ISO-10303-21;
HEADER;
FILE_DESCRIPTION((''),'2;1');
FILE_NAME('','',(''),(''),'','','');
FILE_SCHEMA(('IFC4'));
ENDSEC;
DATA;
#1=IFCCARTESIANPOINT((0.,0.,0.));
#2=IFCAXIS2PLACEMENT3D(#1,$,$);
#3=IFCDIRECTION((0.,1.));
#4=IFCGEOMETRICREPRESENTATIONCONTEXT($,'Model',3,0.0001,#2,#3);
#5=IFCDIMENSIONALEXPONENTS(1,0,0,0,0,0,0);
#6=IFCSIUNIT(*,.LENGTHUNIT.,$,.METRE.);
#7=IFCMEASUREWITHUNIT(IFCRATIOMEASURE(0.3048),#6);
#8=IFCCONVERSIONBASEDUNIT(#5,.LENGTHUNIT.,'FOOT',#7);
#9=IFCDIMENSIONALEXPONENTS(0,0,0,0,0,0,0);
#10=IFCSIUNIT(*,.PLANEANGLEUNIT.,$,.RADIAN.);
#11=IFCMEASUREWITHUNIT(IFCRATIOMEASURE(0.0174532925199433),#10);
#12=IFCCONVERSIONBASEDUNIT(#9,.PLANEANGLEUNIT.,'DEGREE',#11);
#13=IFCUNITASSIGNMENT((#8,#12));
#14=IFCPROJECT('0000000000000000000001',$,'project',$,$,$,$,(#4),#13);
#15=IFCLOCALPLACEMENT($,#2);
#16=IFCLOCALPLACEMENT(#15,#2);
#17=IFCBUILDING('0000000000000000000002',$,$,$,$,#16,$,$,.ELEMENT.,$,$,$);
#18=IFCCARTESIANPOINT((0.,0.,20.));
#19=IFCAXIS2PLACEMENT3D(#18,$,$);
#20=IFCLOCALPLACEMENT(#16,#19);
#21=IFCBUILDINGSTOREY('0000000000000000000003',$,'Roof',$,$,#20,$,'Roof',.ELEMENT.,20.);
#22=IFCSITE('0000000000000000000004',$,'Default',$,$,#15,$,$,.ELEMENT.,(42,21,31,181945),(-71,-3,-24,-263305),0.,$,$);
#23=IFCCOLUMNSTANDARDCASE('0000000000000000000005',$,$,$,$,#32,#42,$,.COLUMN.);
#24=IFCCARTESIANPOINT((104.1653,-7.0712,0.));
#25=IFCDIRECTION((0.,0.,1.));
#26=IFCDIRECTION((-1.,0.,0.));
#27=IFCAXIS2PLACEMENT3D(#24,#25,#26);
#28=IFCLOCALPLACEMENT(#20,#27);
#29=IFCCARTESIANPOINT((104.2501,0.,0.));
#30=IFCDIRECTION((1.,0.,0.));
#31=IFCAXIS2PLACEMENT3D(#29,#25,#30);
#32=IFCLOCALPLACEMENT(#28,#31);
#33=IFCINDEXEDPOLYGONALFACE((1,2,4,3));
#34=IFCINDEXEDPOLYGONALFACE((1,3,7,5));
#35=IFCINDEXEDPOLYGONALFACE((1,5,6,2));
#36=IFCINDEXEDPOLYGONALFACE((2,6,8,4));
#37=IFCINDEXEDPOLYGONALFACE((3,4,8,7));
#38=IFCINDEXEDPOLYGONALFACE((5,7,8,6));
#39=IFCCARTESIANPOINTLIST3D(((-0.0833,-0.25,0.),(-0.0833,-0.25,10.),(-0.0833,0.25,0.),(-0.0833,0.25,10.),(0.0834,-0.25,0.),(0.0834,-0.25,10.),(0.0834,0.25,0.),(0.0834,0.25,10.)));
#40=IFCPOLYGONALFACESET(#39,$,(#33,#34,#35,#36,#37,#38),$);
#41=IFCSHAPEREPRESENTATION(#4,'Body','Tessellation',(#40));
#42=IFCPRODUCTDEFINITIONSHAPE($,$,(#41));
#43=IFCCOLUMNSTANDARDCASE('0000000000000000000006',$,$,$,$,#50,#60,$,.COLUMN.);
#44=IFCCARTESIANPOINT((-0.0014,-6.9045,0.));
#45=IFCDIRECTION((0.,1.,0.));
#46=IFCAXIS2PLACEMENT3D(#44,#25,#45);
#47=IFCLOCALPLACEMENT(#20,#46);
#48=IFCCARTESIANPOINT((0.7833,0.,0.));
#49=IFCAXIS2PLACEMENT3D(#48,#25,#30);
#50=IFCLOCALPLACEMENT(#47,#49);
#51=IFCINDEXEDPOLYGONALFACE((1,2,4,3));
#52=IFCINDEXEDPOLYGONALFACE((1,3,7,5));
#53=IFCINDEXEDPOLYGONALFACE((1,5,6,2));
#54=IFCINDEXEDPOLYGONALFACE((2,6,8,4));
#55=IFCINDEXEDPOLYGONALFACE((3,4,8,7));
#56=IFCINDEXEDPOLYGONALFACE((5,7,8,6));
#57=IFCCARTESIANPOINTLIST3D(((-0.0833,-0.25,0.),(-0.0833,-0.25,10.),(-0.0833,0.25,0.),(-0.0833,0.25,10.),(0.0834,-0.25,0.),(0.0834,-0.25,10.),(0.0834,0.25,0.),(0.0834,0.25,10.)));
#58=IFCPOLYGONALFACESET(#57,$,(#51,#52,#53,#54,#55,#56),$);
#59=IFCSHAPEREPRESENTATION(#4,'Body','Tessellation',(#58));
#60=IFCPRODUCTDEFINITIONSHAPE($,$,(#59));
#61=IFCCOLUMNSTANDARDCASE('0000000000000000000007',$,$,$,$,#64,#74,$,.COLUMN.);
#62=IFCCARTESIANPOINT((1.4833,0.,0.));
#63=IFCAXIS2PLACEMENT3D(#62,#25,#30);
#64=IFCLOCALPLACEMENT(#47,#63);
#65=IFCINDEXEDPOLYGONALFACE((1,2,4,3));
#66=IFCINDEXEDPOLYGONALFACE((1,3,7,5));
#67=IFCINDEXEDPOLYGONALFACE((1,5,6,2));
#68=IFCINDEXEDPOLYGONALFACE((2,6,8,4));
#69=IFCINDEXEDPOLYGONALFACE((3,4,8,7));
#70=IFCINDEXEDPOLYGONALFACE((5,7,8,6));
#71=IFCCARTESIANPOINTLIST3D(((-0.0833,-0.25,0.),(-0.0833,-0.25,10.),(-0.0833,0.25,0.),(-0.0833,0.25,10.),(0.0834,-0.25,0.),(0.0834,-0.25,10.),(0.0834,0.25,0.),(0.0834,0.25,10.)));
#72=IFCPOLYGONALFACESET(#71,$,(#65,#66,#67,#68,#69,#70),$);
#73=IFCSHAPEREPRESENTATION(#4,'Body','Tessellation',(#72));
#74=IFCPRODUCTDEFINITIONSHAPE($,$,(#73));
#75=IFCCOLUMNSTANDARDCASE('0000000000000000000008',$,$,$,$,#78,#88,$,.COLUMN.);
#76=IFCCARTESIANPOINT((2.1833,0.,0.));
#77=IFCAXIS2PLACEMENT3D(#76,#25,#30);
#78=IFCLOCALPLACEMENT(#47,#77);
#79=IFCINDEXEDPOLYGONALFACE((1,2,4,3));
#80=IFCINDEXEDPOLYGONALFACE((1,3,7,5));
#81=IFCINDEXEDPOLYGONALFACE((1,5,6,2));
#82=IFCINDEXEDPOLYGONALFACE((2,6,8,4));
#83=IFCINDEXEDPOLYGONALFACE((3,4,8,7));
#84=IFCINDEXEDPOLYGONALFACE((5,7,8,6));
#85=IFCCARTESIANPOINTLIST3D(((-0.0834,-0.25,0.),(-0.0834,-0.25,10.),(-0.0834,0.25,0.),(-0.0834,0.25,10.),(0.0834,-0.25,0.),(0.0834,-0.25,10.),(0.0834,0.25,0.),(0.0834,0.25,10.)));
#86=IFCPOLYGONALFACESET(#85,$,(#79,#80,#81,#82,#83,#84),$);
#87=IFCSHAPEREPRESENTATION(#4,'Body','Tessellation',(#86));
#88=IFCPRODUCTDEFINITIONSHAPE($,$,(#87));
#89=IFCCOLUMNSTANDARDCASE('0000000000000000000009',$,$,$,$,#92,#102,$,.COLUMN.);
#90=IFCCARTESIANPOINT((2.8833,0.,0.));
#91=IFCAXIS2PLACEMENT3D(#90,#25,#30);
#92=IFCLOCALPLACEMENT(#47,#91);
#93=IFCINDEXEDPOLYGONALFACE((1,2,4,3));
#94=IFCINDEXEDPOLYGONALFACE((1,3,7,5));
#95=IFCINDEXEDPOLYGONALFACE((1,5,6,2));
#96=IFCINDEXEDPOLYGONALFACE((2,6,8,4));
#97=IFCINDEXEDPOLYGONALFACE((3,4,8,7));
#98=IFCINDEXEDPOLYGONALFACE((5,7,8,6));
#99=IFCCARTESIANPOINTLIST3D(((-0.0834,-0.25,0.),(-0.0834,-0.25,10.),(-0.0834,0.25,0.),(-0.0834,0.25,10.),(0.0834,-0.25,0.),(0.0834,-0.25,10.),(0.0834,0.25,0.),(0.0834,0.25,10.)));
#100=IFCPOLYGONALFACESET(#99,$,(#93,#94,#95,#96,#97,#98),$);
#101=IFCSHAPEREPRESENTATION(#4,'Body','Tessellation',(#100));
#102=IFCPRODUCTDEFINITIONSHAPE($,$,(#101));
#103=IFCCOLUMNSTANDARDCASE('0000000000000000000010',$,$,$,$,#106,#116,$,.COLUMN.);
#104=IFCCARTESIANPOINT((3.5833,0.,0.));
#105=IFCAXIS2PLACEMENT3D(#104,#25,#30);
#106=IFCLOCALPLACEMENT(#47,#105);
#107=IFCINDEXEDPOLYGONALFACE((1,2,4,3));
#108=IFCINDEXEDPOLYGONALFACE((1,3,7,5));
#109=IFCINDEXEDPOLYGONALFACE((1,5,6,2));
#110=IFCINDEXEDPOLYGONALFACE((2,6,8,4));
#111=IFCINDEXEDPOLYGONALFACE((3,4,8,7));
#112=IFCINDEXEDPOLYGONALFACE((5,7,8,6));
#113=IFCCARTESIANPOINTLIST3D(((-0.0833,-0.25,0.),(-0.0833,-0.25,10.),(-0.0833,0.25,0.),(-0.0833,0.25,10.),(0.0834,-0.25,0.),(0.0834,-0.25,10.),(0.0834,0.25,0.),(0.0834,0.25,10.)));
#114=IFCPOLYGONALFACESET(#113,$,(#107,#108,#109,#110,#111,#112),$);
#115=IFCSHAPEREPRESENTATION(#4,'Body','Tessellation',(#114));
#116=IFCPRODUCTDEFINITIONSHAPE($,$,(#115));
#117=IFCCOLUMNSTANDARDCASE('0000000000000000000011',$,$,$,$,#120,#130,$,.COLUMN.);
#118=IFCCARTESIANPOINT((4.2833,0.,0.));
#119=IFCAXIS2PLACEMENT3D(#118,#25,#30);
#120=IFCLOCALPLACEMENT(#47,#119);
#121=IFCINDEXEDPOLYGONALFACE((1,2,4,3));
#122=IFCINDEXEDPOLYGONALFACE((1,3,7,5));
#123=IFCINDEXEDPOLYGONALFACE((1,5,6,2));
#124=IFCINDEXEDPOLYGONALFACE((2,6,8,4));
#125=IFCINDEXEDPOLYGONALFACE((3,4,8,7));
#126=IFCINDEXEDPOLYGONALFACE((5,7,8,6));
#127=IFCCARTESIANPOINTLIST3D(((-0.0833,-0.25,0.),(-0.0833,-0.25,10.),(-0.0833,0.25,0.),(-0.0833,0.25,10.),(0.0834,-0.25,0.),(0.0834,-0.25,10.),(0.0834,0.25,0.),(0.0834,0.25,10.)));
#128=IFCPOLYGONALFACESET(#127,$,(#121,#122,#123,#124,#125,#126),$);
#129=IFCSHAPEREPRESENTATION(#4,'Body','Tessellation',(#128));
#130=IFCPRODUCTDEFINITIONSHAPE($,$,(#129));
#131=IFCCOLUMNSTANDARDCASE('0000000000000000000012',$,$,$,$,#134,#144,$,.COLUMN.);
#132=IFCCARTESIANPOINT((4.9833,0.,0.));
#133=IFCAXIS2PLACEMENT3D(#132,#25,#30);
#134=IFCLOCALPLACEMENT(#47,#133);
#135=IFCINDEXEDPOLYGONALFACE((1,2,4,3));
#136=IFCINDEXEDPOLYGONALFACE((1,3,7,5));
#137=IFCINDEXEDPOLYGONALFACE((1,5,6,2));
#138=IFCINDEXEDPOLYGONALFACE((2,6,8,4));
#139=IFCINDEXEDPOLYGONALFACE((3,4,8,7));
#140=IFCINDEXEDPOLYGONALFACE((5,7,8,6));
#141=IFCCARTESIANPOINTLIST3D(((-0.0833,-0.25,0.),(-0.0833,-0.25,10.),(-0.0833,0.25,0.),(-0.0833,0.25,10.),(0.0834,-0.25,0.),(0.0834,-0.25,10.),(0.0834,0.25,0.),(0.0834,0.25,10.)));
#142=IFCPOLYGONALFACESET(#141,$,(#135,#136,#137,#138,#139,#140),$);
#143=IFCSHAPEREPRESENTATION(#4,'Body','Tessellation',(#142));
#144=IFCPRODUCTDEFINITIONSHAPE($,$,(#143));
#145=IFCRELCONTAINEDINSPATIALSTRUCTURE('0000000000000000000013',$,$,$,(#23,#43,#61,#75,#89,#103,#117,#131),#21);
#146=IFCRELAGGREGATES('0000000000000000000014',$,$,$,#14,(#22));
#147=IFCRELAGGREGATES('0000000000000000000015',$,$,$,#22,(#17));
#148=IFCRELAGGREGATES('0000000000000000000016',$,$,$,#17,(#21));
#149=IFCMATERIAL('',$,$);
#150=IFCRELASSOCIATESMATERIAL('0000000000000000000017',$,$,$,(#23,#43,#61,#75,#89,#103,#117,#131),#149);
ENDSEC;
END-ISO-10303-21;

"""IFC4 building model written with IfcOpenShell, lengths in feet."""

from ifc_helpers import new_model, entity, si_unit, converted_unit, direction, frame, origin, place, context, project, spatial, rectangle, extrude, material, element, save


model = new_model("IFC4")

# Units and contexts
model_context = context("Model", 3, precision=0.0001, world=origin(), true_north=direction((0.0, 1.0)))
ifc_project = project(units=[converted_unit("LENGTHUNIT", "FOOT", entity("IfcRatioMeasure", 0.3048), si_unit("LENGTHUNIT", "METRE"), dimensions=[1, 0, 0, 0, 0, 0, 0]), converted_unit("PLANEANGLEUNIT", "DEGREE", entity("IfcRatioMeasure", 0.0174532925199433), si_unit("PLANEANGLEUNIT", "RADIAN"), dimensions=[0, 0, 0, 0, 0, 0, 0])], contexts=[model_context])

# Site, building, storey
site_placement = place(None, origin())
site = spatial("IfcSite", under=ifc_project, at=site_placement, Name="Default", CompositionType="ELEMENT", RefLatitude=(42, 21, 31, 181945), RefLongitude=(-71, -3, -24, -263305), RefElevation=0.0)
building_placement = place(site_placement, origin())
building = spatial("IfcBuilding", under=site, at=building_placement, CompositionType="ELEMENT")
storey_placement = place(building_placement, frame((0.0, 0.0, 20.0)))
storey = spatial("IfcBuildingStorey", under=building, at=storey_placement, Name="Roof", LongName="Roof", CompositionType="ELEMENT", Elevation=20.0)

# Columns
ifc_material_1 = material(Name="")
placement_1 = place(storey_placement, frame((104.1653, -7.0712, 0.0), z_axis=(0.0, 0.0, 1.0), x_axis=(-1.0, 0.0, 0.0)))
for number, where, z_axis, x_axis in (
    (1, (104.2501, 0.0, 0.0), (0.0, 0.0, 1.0), (1.0, 0.0, 0.0)),
):
    element("IfcColumnStandardCase", number, at=place(placement_1, frame(where, z_axis=z_axis, x_axis=x_axis)), inside=storey, material=ifc_material_1, PredefinedType="COLUMN", context=model_context, shape_type="SweptSolid", body=[
        extrude(rectangle(XDim=0.1667, YDim=0.5), origin(), (0.0, 0.0, 1.0), 10.0),
    ])
placement_2 = place(storey_placement, frame((-0.0014, -6.9045, 0.0), z_axis=(0.0, 0.0, 1.0), x_axis=(0.0, 1.0, 0.0)))
for number, where, z_axis, x_axis in (
    (2, (0.7833, 0.0, 0.0), (0.0, 0.0, 1.0), (1.0, 0.0, 0.0)),
    (3, (1.4833, 0.0, 0.0), (0.0, 0.0, 1.0), (1.0, 0.0, 0.0)),
    (4, (2.1833, 0.0, 0.0), (0.0, 0.0, 1.0), (1.0, 0.0, 0.0)),
    (5, (2.8833, 0.0, 0.0), (0.0, 0.0, 1.0), (1.0, 0.0, 0.0)),
    (6, (3.5833, 0.0, 0.0), (0.0, 0.0, 1.0), (1.0, 0.0, 0.0)),
    (7, (4.2833, 0.0, 0.0), (0.0, 0.0, 1.0), (1.0, 0.0, 0.0)),
    (8, (4.9833, 0.0, 0.0), (0.0, 0.0, 1.0), (1.0, 0.0, 0.0)),
):
    element("IfcColumnStandardCase", number, at=place(placement_2, frame(where, z_axis=z_axis, x_axis=x_axis)), inside=storey, material=ifc_material_1, PredefinedType="COLUMN", context=model_context, shape_type="SweptSolid", body=[
        extrude(rectangle(XDim=0.1667, YDim=0.5), origin(), (0.0, 0.0, 1.0), 10.0),
    ])

save(model, "model.ifc")
